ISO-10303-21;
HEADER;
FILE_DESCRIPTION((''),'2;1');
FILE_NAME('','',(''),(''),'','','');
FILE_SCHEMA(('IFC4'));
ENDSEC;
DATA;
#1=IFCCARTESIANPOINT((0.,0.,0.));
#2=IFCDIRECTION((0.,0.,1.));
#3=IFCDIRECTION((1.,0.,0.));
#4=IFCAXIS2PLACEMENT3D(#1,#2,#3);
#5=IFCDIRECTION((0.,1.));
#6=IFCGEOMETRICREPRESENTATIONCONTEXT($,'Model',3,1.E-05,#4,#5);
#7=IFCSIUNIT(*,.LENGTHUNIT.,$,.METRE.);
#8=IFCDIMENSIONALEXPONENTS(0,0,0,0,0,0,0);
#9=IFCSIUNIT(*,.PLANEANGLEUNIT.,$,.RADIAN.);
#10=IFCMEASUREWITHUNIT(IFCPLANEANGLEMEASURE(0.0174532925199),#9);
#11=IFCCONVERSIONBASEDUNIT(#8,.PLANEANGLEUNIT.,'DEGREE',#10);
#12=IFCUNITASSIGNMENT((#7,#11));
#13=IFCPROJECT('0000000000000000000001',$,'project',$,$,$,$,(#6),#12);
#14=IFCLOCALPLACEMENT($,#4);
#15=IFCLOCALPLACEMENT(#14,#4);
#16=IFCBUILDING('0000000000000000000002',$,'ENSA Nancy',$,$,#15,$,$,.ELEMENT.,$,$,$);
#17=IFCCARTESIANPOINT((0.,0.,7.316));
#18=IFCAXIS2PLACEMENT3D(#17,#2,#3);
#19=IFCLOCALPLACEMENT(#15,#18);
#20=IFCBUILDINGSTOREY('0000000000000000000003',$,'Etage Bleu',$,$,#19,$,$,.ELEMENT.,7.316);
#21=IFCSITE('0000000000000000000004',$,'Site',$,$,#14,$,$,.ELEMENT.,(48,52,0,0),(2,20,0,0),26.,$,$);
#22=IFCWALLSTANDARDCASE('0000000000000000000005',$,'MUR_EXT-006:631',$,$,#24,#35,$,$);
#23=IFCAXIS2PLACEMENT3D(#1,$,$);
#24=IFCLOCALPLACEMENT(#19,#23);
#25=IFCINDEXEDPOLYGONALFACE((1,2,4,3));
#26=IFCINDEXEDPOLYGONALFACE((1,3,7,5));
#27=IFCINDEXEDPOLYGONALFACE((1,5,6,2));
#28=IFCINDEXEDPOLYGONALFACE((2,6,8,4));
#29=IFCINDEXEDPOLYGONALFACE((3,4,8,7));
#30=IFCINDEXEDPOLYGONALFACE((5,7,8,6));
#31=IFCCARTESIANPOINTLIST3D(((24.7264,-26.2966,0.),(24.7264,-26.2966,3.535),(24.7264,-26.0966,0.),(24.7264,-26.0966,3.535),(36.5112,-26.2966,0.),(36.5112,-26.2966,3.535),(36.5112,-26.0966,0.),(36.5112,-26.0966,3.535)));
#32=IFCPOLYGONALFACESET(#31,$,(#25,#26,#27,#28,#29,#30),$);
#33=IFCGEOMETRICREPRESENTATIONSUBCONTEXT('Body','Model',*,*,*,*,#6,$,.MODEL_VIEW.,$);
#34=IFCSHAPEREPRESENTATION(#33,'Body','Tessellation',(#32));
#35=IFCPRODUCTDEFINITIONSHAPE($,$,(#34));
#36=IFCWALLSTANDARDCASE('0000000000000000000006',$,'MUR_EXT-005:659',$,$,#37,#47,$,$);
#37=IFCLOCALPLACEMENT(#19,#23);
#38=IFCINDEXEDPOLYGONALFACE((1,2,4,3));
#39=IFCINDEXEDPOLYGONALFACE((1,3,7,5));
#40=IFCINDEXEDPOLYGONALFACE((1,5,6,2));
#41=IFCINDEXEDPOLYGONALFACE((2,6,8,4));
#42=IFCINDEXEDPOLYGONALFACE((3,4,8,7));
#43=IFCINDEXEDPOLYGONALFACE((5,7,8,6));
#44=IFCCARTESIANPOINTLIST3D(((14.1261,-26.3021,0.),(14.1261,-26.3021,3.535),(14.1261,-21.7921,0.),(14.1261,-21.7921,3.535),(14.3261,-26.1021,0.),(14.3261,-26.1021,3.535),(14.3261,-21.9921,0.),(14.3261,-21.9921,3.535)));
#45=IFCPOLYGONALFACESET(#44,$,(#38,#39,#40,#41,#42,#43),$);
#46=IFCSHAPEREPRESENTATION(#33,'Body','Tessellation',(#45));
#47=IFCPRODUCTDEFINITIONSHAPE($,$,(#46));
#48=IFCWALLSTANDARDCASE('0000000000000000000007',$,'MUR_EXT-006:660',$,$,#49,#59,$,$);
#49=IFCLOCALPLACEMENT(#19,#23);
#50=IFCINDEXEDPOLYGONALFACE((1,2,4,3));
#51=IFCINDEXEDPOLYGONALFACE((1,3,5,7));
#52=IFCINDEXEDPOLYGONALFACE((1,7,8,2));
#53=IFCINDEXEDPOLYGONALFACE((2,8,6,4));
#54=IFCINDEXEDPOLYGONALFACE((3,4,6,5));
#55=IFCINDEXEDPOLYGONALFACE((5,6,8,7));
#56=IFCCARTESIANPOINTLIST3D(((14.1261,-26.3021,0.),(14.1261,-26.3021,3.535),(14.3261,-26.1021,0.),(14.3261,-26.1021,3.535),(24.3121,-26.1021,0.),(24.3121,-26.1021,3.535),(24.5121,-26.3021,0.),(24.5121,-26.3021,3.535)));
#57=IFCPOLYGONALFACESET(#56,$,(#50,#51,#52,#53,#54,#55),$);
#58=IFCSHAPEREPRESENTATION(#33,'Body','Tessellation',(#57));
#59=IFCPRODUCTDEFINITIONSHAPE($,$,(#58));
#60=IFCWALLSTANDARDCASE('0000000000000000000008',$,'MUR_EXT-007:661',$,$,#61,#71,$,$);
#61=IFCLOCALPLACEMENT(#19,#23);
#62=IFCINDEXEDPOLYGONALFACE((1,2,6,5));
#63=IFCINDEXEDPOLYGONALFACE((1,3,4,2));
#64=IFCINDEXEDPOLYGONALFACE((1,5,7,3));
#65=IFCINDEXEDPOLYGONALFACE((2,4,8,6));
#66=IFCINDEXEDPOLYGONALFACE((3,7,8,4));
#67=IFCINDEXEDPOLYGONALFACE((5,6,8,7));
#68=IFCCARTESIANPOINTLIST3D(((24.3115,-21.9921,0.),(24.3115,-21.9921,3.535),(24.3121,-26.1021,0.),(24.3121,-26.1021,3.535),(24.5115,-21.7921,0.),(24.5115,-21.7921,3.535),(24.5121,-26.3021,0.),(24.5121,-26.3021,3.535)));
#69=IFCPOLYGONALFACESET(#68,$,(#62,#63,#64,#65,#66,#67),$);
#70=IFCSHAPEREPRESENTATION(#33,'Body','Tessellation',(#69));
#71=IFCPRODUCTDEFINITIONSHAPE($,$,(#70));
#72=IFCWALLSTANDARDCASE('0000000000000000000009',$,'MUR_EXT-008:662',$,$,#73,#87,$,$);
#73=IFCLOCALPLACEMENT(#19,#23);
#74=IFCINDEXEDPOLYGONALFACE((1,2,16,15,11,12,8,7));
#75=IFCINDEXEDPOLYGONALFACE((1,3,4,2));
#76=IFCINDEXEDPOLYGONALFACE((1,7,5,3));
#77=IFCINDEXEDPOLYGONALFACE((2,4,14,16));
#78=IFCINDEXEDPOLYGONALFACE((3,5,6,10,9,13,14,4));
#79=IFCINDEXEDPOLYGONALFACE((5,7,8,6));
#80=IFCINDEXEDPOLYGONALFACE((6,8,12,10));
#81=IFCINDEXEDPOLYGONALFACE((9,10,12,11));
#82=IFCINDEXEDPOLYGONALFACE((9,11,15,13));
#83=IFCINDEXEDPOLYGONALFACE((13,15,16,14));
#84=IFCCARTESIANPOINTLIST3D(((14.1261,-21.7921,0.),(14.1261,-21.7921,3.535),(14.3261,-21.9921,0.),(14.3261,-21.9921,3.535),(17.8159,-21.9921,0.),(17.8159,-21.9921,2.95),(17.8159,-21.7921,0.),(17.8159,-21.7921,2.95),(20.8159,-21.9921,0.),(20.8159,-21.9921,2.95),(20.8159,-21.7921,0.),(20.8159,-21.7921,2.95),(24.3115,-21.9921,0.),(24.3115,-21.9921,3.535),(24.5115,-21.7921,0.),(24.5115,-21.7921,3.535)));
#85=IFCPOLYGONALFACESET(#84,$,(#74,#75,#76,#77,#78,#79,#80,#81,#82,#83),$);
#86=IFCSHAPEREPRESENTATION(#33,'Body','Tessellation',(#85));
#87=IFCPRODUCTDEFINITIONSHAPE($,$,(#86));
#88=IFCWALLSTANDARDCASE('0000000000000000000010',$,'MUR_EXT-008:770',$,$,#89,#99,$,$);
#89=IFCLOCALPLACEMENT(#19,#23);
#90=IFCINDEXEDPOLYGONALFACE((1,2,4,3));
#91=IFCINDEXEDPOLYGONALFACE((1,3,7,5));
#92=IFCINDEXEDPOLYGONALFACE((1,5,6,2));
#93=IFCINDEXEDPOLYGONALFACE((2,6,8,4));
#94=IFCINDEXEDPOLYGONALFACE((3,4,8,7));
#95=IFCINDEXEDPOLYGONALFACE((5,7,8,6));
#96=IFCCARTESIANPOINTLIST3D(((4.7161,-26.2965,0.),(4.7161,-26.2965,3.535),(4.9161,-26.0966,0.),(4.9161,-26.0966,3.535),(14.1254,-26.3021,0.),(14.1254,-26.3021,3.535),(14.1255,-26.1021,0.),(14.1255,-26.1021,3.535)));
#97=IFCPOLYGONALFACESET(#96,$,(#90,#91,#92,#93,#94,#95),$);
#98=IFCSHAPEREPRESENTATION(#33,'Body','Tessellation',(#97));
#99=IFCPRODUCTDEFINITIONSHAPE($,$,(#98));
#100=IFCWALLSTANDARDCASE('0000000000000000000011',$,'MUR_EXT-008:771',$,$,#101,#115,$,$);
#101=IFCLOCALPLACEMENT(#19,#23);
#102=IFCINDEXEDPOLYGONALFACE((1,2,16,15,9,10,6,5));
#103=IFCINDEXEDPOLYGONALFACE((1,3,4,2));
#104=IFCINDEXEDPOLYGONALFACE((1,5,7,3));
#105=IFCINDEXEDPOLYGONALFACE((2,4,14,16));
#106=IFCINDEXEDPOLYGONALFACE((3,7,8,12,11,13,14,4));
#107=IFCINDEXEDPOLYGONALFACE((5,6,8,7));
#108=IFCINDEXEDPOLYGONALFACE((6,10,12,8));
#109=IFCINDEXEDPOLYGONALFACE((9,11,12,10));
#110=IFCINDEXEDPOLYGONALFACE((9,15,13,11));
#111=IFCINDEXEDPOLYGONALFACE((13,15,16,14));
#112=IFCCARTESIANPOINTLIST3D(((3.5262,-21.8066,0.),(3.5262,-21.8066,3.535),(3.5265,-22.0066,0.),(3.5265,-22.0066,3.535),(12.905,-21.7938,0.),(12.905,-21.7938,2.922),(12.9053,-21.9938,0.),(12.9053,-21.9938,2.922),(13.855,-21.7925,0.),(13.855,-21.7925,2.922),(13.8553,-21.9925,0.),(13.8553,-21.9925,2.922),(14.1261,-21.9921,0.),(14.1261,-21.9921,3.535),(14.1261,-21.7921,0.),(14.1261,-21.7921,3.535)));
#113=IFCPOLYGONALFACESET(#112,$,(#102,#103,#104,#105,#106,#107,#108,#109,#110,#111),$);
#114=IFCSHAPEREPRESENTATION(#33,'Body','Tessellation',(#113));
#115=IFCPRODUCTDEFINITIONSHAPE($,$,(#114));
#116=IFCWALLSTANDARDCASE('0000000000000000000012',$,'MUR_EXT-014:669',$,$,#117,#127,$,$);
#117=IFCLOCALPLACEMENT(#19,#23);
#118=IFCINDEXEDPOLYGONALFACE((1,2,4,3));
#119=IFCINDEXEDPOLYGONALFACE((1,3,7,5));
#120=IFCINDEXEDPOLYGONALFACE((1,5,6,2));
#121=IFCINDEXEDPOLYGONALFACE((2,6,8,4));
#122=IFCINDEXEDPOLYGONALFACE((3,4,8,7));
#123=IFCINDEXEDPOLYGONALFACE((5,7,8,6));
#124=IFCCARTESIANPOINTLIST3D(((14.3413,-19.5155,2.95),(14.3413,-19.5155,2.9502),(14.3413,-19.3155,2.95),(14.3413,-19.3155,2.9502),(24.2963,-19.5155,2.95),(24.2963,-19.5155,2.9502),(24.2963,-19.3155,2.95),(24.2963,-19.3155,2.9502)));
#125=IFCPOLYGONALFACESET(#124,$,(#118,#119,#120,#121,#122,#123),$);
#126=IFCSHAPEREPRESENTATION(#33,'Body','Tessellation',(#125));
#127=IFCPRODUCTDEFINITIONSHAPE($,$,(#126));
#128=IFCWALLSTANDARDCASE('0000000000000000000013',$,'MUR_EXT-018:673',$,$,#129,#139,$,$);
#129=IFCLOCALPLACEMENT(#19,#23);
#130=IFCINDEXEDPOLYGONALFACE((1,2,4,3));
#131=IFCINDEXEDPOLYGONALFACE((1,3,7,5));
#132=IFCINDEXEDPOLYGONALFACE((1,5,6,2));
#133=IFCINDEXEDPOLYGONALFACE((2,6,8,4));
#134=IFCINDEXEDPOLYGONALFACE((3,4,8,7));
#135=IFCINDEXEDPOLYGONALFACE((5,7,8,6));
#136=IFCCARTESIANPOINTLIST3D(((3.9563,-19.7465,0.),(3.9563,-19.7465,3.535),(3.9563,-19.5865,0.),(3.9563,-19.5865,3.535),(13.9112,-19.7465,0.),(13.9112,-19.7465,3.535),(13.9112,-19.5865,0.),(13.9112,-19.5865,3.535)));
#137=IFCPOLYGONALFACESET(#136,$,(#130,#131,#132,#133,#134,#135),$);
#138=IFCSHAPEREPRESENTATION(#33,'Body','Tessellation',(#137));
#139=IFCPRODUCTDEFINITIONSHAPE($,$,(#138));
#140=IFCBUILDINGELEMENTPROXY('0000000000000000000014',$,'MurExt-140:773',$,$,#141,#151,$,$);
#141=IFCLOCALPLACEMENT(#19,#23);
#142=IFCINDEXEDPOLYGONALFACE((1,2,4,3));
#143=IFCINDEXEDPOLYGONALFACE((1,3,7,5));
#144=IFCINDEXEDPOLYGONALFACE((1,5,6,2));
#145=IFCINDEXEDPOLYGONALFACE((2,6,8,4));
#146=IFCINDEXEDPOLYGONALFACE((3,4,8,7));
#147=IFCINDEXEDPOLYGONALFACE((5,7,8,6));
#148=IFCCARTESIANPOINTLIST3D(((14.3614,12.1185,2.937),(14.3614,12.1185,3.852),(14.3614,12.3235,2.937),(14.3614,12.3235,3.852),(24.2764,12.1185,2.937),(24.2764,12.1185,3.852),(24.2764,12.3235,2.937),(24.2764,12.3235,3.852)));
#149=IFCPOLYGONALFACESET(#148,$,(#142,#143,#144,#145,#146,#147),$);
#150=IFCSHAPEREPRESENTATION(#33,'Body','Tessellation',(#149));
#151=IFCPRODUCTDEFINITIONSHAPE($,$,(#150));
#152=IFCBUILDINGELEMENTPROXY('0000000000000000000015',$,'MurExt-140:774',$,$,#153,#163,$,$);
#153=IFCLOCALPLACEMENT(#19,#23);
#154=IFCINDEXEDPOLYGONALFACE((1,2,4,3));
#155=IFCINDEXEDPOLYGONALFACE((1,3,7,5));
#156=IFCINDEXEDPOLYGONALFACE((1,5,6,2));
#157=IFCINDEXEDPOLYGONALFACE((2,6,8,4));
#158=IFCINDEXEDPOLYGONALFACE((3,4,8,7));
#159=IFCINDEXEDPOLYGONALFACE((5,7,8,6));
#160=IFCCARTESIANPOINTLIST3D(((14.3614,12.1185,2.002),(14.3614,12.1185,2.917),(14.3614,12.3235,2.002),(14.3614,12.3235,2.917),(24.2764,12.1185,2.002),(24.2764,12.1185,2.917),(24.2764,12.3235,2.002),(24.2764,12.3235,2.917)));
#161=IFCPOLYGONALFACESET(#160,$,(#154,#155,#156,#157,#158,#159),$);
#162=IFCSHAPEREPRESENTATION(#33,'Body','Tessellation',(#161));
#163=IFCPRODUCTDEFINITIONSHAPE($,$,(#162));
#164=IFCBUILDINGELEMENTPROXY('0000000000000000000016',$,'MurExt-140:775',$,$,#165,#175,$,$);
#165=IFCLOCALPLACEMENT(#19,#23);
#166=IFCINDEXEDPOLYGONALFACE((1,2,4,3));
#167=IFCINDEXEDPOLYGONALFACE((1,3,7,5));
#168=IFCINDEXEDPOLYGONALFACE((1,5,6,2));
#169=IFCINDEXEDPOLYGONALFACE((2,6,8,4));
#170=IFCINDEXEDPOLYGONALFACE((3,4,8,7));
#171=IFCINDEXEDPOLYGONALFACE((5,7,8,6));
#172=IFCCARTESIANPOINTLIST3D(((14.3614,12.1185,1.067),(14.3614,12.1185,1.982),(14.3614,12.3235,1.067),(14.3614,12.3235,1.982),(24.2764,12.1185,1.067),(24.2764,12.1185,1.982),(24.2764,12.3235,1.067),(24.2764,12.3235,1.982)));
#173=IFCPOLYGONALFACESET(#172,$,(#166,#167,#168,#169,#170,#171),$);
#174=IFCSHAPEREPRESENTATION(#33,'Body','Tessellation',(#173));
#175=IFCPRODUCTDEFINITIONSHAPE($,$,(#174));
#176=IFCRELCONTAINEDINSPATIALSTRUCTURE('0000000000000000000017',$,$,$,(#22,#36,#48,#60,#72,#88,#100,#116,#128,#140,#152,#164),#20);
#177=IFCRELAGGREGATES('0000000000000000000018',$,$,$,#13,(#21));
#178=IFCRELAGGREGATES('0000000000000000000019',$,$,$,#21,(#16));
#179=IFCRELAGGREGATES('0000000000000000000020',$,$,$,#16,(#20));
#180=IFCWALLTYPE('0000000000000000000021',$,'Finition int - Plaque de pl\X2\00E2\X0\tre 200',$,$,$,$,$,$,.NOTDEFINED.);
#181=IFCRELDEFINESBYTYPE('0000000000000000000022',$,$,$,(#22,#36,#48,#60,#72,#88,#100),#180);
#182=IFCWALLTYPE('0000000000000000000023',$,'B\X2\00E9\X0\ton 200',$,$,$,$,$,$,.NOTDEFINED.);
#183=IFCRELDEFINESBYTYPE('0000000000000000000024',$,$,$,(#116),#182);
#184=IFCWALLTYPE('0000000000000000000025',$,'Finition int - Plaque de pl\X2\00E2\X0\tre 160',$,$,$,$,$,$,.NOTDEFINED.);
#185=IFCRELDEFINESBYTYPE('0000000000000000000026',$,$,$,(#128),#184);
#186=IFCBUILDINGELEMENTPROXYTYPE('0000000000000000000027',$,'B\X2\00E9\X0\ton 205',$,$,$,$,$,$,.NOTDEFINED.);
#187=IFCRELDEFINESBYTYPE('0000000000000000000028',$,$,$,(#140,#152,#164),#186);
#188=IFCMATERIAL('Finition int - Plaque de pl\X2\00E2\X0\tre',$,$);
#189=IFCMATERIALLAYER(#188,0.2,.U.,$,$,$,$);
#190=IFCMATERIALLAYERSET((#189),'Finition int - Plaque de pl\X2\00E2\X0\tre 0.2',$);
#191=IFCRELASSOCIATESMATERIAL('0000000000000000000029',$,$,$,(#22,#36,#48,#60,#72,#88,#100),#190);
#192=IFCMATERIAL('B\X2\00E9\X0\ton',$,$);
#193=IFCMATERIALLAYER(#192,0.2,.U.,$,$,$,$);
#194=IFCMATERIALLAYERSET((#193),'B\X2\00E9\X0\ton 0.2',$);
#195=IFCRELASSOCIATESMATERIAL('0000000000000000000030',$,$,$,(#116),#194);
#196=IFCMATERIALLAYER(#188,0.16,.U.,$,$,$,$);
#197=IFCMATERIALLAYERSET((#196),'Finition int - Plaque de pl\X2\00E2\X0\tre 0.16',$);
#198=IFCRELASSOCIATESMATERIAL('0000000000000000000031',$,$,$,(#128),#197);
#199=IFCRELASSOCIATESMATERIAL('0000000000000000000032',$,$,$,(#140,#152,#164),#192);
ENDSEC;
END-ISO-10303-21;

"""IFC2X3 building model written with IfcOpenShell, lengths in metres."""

from ifc_helpers import new_model, entity, si_unit, converted_unit, direction, frame, origin_with_axes, origin_2d_with_axis, place, context, subcontext, project, spatial, polyline, rectangle, outline, extrude, material, layer, layer_set, layer_usage, type_object, element, save


model = new_model("IFC2X3")

# Units and contexts
model_context = context("Model", 3, precision=1e-05, world=origin_with_axes(), true_north=direction((0.0, 1.0)))
body_context = subcontext(model_context, "Body", "Model", "MODEL_VIEW")
ifc_project = project(units=[si_unit("LENGTHUNIT", "METRE"), converted_unit("PLANEANGLEUNIT", "DEGREE", entity("IfcPlaneAngleMeasure", 0.0174532925199), si_unit("PLANEANGLEUNIT", "RADIAN"), dimensions=[0, 0, 0, 0, 0, 0, 0])], contexts=[model_context])

# Site, building, storey
site_placement = place(None, origin_with_axes())
site = spatial("IfcSite", under=ifc_project, at=site_placement, Name="Site", CompositionType="ELEMENT", RefLatitude=(48, 52, 0, 0), RefLongitude=(2, 20, 0, 0), RefElevation=26.0)
building_placement = place(site_placement, origin_with_axes())
building = spatial("IfcBuilding", under=site, at=building_placement, Name="ENSA Nancy", CompositionType="ELEMENT")
storey_placement = place(building_placement, frame((0.0, 0.0, 7.316), z_axis=(0.0, 0.0, 1.0), x_axis=(1.0, 0.0, 0.0)))
storey = spatial("IfcBuildingStorey", under=building, at=storey_placement, Name="Etage Bleu", CompositionType="ELEMENT", Elevation=7.316)

# Walls
ifc_material_1 = material(Name="Finition int - Plaque de plâtre")
ifc_layer_1 = layer(ifc_material_1, 0.2, ventilated="UNKNOWN")
ifc_layer_set_1 = layer_set([ifc_layer_1], Name="Finition int - Plaque de plâtre 0.2")
ifc_layer_usage_1 = layer_usage(ifc_layer_set_1, "AXIS2", "NEGATIVE", 0.0)
wall_type_1 = type_object("IfcWallType", Name="Finition int - Plaque de plâtre 200", PredefinedType="NOTDEFINED")
wall_1_placement = place(storey_placement, frame((36.5112, -26.2966, 0.0), z_axis=(0.0, 0.0, 1.0), x_axis=(-1.0, 0.0, 0.0)))
element("IfcWallStandardCase", 1, at=wall_1_placement, inside=storey, type_object=wall_type_1, material=ifc_layer_usage_1, Name="MUR_EXT-006:631", context=body_context, shape_type="SweptSolid", body=[
    extrude(outline(polyline([(0.0, -0.2), (11.7849, -0.2), (11.7849, 0.0), (0.0, 0.0), (0.0, -0.2)])), origin_with_axes(), (0.0, 0.0, 1.0), 3.535),
])
ifc_layer_usage_2 = layer_usage(ifc_layer_set_1, "AXIS2", "POSITIVE", 0.0)
wall_2_placement = place(storey_placement, frame((14.1261, -21.7921, 0.0), z_axis=(0.0, 0.0, 1.0), x_axis=(0.0, -1.0, 0.0)))
element("IfcWallStandardCase", 2, at=wall_2_placement, inside=storey, type_object=wall_type_1, material=ifc_layer_usage_2, Name="MUR_EXT-005:659", context=body_context, shape_type="SweptSolid", body=[
    extrude(outline(polyline([(0.0, 0.0), (4.51, 0.0), (4.31, 0.2), (0.2, 0.2), (0.0, 0.0)])), origin_with_axes(), (0.0, 0.0, 1.0), 3.535),
])
ifc_layer_usage_3 = layer_usage(ifc_layer_set_1, "AXIS2", "POSITIVE", 0.0)
wall_3_placement = place(storey_placement, frame((14.1261, -26.3021, 0.0), z_axis=(0.0, 0.0, 1.0), x_axis=(1.0, 0.000003, 0.0)))
element("IfcWallStandardCase", 3, at=wall_3_placement, inside=storey, type_object=wall_type_1, material=ifc_layer_usage_3, Name="MUR_EXT-006:660", context=body_context, shape_type="SweptSolid", body=[
    extrude(outline(polyline([(0.0, 0.0), (10.386, 0.0), (10.186, 0.2), (0.2, 0.2), (0.0, 0.0)])), origin_with_axes(), (0.0, 0.0, 1.0), 3.535),
])
ifc_layer_usage_4 = layer_usage(ifc_layer_set_1, "AXIS2", "POSITIVE", 0.0)
wall_4_placement = place(storey_placement, frame((24.5121, -26.3021, 0.0), z_axis=(0.0, 0.0, 1.0), x_axis=(-0.00015, 1.0, 0.0)))
element("IfcWallStandardCase", 4, at=wall_4_placement, inside=storey, type_object=wall_type_1, material=ifc_layer_usage_4, Name="MUR_EXT-007:661", context=body_context, shape_type="SweptSolid", body=[
    extrude(outline(polyline([(0.0, 0.0), (4.51, 0.0), (4.31, 0.2), (0.2, 0.2), (0.0, 0.0)])), origin_with_axes(), (0.0, 0.0, 1.0), 3.535),
])

# Wall, opening
ifc_layer_usage_5 = layer_usage(ifc_layer_set_1, "AXIS2", "POSITIVE", 0.0)
wall_5_placement = place(storey_placement, frame((24.5115, -21.7921, 0.0), z_axis=(0.0, 0.0, 1.0), x_axis=(-1.0, -0.000003, 0.0)))
wall_5 = element("IfcWallStandardCase", 5, at=wall_5_placement, inside=storey, type_object=wall_type_1, material=ifc_layer_usage_5, Name="MUR_EXT-008:662", context=body_context, shape_type="SweptSolid", body=[
    extrude(outline(polyline([(0.0, 0.0), (10.3854, 0.0), (10.1854, 0.2), (0.2, 0.2), (0.0, 0.0)])), origin_with_axes(), (0.0, 0.0, 1.0), 3.535),
])
opening_1_placement = place(wall_5_placement, frame((5.1955, 0.0, 0.0), z_axis=(0.0, 0.0, 1.0), x_axis=(1.0, 0.0, 0.0)))
element("IfcOpeningElement", 6, at=opening_1_placement, cuts=wall_5, context=body_context, shape_type="SweptSolid", body=[
    extrude(rectangle(XDim=3.0, YDim=2.95, at=origin_2d_with_axis()), frame((0.0, 0.2, 1.475), z_axis=(0.0, -1.0, 0.0), x_axis=(1.0, 0.0, 0.0)), (0.0, 0.0, 1.0), 0.6),
])

# Wall
ifc_layer_usage_6 = layer_usage(ifc_layer_set_1, "AXIS2", "POSITIVE", 0.0)
wall_6_placement = place(storey_placement, frame((4.7161, -26.2965, 0.0), z_axis=(0.0, 0.0, 1.0), x_axis=(1.0, -0.000596, 0.0)))
element("IfcWallStandardCase", 7, at=wall_6_placement, inside=storey, type_object=wall_type_1, material=ifc_layer_usage_6, Name="MUR_EXT-008:770", context=body_context, shape_type="SweptSolid", body=[
    extrude(outline(polyline([(0.0, 0.0), (9.4092, 0.0), (9.4092, 0.2), (0.1999, 0.2), (0.0, 0.0)])), origin_with_axes(), (0.0, 0.0, 1.0), 3.535),
])

# Walls, openings
ifc_layer_usage_7 = layer_usage(ifc_layer_set_1, "AXIS2", "NEGATIVE", 0.0)
wall_7_placement = place(storey_placement, frame((3.5262, -21.8066, 0.0), z_axis=(0.0, 0.0, 1.0), x_axis=(0.999999, 0.001365, 0.0)))
wall_7 = element("IfcWallStandardCase", 8, at=wall_7_placement, inside=storey, type_object=wall_type_1, material=ifc_layer_usage_7, Name="MUR_EXT-008:771", context=body_context, shape_type="SweptSolid", body=[
    extrude(outline(polyline([(0.0, -0.2), (10.5996, -0.2), (10.5999, 0.0), (0.0, 0.0), (0.0, -0.2)])), origin_with_axes(), (0.0, 0.0, 1.0), 3.535),
])
opening_2_placement = place(wall_7_placement, frame((9.8538, 0.0, 0.0), z_axis=(0.0, 0.0, 1.0), x_axis=(1.0, 0.0, 0.0)))
element("IfcOpeningElement", 9, at=opening_2_placement, cuts=wall_7, context=body_context, shape_type="SweptSolid", body=[
    extrude(rectangle(XDim=0.95, YDim=2.922, at=origin_2d_with_axis()), frame((0.0, -0.2, 1.461), z_axis=(0.0, 1.0, 0.0), x_axis=(1.0, 0.0, 0.0)), (0.0, 0.0, 1.0), 0.6),
])
ifc_material_2 = material(Name="Béton")
ifc_layer_2 = layer(ifc_material_2, 0.2, ventilated="UNKNOWN")
ifc_layer_set_2 = layer_set([ifc_layer_2], Name="Béton 0.2")
ifc_layer_usage_8 = layer_usage(ifc_layer_set_2, "AXIS2", "POSITIVE", -0.2)
wall_type_2 = type_object("IfcWallType", Name="Béton 200", PredefinedType="NOTDEFINED")
wall_8_placement = place(storey_placement, frame((14.3413, -19.3155, 0.0), z_axis=(0.0, 0.0, 1.0), x_axis=(1.0, 0.0, 0.0)))
wall_8 = element("IfcWallStandardCase", 10, at=wall_8_placement, inside=storey, type_object=wall_type_2, material=ifc_layer_usage_8, Name="MUR_EXT-014:669", context=body_context, shape_type="SweptSolid", body=[
    extrude(outline(polyline([(0.0, -0.2), (9.955, -0.2), (9.955, 0.0), (0.0, 0.0), (0.0, -0.2)])), origin_with_axes(), (0.0, 0.0, 1.0), 2.9502),
])
opening_3_placement = place(wall_8_placement, frame((4.9775, 0.0, 0.0), z_axis=(0.0, 0.0, 1.0), x_axis=(1.0, 0.0, 0.0)))
element("IfcOpeningElement", 11, at=opening_3_placement, cuts=wall_8, context=body_context, shape_type="SweptSolid", body=[
    extrude(rectangle(XDim=9.955, YDim=2.95, at=origin_2d_with_axis()), frame((0.0, -0.2, 1.475), z_axis=(0.0, -1.0, 0.0), x_axis=(1.0, 0.0, 0.0)), (0.0, 0.0, -1.0), 0.6),
])

# Wall
ifc_layer_3 = layer(ifc_material_1, 0.16, ventilated="UNKNOWN")
ifc_layer_set_3 = layer_set([ifc_layer_3], Name="Finition int - Plaque de plâtre 0.16")
ifc_layer_usage_9 = layer_usage(ifc_layer_set_3, "AXIS2", "POSITIVE", -0.16)
wall_type_3 = type_object("IfcWallType", Name="Finition int - Plaque de plâtre 160", PredefinedType="NOTDEFINED")
wall_9_placement = place(storey_placement, frame((3.9563, -19.5865, 0.0), z_axis=(0.0, 0.0, 1.0), x_axis=(1.0, 0.0, 0.0)))
element("IfcWallStandardCase", 12, at=wall_9_placement, inside=storey, type_object=wall_type_3, material=ifc_layer_usage_9, Name="MUR_EXT-018:673", context=body_context, shape_type="SweptSolid", body=[
    extrude(outline(polyline([(0.0, -0.16), (9.955, -0.16), (9.955, 0.0), (0.0, 0.0), (0.0, -0.16)])), origin_with_axes(), (0.0, 0.0, 1.0), 3.535),
])

# Building element proxies
building_element_proxy_type_1 = type_object("IfcBuildingElementProxyType", Name="Béton 205", PredefinedType="NOTDEFINED")
for number, where, z_axis, x_axis, name in (
    (13, (14.3614, 12.3235, 2.937), (0.0, 0.0, 1.0), (1.0, 0.0, 0.0), "MurExt-140:773"),
    (14, (14.3614, 12.3235, 2.002), (0.0, 0.0, 1.0), (1.0, 0.0, 0.0), "MurExt-140:774"),
    (15, (14.3614, 12.3235, 1.067), (0.0, 0.0, 1.0), (1.0, 0.0, 0.0), "MurExt-140:775"),
):
    element("IfcBuildingElementProxy", number, at=place(storey_placement, frame(where, z_axis=z_axis, x_axis=x_axis)), inside=storey, type_object=building_element_proxy_type_1, material=ifc_material_2, Name=name, context=body_context, shape_type="SweptSolid", body=[
        extrude(outline(polyline([(0.0, -0.205), (9.915, -0.205), (9.915, 0.0), (0.0, 0.0), (0.0, -0.205)])), origin_with_axes(), (0.0, 0.0, 1.0), 0.915),
    ])

save(model, "model.ifc")
